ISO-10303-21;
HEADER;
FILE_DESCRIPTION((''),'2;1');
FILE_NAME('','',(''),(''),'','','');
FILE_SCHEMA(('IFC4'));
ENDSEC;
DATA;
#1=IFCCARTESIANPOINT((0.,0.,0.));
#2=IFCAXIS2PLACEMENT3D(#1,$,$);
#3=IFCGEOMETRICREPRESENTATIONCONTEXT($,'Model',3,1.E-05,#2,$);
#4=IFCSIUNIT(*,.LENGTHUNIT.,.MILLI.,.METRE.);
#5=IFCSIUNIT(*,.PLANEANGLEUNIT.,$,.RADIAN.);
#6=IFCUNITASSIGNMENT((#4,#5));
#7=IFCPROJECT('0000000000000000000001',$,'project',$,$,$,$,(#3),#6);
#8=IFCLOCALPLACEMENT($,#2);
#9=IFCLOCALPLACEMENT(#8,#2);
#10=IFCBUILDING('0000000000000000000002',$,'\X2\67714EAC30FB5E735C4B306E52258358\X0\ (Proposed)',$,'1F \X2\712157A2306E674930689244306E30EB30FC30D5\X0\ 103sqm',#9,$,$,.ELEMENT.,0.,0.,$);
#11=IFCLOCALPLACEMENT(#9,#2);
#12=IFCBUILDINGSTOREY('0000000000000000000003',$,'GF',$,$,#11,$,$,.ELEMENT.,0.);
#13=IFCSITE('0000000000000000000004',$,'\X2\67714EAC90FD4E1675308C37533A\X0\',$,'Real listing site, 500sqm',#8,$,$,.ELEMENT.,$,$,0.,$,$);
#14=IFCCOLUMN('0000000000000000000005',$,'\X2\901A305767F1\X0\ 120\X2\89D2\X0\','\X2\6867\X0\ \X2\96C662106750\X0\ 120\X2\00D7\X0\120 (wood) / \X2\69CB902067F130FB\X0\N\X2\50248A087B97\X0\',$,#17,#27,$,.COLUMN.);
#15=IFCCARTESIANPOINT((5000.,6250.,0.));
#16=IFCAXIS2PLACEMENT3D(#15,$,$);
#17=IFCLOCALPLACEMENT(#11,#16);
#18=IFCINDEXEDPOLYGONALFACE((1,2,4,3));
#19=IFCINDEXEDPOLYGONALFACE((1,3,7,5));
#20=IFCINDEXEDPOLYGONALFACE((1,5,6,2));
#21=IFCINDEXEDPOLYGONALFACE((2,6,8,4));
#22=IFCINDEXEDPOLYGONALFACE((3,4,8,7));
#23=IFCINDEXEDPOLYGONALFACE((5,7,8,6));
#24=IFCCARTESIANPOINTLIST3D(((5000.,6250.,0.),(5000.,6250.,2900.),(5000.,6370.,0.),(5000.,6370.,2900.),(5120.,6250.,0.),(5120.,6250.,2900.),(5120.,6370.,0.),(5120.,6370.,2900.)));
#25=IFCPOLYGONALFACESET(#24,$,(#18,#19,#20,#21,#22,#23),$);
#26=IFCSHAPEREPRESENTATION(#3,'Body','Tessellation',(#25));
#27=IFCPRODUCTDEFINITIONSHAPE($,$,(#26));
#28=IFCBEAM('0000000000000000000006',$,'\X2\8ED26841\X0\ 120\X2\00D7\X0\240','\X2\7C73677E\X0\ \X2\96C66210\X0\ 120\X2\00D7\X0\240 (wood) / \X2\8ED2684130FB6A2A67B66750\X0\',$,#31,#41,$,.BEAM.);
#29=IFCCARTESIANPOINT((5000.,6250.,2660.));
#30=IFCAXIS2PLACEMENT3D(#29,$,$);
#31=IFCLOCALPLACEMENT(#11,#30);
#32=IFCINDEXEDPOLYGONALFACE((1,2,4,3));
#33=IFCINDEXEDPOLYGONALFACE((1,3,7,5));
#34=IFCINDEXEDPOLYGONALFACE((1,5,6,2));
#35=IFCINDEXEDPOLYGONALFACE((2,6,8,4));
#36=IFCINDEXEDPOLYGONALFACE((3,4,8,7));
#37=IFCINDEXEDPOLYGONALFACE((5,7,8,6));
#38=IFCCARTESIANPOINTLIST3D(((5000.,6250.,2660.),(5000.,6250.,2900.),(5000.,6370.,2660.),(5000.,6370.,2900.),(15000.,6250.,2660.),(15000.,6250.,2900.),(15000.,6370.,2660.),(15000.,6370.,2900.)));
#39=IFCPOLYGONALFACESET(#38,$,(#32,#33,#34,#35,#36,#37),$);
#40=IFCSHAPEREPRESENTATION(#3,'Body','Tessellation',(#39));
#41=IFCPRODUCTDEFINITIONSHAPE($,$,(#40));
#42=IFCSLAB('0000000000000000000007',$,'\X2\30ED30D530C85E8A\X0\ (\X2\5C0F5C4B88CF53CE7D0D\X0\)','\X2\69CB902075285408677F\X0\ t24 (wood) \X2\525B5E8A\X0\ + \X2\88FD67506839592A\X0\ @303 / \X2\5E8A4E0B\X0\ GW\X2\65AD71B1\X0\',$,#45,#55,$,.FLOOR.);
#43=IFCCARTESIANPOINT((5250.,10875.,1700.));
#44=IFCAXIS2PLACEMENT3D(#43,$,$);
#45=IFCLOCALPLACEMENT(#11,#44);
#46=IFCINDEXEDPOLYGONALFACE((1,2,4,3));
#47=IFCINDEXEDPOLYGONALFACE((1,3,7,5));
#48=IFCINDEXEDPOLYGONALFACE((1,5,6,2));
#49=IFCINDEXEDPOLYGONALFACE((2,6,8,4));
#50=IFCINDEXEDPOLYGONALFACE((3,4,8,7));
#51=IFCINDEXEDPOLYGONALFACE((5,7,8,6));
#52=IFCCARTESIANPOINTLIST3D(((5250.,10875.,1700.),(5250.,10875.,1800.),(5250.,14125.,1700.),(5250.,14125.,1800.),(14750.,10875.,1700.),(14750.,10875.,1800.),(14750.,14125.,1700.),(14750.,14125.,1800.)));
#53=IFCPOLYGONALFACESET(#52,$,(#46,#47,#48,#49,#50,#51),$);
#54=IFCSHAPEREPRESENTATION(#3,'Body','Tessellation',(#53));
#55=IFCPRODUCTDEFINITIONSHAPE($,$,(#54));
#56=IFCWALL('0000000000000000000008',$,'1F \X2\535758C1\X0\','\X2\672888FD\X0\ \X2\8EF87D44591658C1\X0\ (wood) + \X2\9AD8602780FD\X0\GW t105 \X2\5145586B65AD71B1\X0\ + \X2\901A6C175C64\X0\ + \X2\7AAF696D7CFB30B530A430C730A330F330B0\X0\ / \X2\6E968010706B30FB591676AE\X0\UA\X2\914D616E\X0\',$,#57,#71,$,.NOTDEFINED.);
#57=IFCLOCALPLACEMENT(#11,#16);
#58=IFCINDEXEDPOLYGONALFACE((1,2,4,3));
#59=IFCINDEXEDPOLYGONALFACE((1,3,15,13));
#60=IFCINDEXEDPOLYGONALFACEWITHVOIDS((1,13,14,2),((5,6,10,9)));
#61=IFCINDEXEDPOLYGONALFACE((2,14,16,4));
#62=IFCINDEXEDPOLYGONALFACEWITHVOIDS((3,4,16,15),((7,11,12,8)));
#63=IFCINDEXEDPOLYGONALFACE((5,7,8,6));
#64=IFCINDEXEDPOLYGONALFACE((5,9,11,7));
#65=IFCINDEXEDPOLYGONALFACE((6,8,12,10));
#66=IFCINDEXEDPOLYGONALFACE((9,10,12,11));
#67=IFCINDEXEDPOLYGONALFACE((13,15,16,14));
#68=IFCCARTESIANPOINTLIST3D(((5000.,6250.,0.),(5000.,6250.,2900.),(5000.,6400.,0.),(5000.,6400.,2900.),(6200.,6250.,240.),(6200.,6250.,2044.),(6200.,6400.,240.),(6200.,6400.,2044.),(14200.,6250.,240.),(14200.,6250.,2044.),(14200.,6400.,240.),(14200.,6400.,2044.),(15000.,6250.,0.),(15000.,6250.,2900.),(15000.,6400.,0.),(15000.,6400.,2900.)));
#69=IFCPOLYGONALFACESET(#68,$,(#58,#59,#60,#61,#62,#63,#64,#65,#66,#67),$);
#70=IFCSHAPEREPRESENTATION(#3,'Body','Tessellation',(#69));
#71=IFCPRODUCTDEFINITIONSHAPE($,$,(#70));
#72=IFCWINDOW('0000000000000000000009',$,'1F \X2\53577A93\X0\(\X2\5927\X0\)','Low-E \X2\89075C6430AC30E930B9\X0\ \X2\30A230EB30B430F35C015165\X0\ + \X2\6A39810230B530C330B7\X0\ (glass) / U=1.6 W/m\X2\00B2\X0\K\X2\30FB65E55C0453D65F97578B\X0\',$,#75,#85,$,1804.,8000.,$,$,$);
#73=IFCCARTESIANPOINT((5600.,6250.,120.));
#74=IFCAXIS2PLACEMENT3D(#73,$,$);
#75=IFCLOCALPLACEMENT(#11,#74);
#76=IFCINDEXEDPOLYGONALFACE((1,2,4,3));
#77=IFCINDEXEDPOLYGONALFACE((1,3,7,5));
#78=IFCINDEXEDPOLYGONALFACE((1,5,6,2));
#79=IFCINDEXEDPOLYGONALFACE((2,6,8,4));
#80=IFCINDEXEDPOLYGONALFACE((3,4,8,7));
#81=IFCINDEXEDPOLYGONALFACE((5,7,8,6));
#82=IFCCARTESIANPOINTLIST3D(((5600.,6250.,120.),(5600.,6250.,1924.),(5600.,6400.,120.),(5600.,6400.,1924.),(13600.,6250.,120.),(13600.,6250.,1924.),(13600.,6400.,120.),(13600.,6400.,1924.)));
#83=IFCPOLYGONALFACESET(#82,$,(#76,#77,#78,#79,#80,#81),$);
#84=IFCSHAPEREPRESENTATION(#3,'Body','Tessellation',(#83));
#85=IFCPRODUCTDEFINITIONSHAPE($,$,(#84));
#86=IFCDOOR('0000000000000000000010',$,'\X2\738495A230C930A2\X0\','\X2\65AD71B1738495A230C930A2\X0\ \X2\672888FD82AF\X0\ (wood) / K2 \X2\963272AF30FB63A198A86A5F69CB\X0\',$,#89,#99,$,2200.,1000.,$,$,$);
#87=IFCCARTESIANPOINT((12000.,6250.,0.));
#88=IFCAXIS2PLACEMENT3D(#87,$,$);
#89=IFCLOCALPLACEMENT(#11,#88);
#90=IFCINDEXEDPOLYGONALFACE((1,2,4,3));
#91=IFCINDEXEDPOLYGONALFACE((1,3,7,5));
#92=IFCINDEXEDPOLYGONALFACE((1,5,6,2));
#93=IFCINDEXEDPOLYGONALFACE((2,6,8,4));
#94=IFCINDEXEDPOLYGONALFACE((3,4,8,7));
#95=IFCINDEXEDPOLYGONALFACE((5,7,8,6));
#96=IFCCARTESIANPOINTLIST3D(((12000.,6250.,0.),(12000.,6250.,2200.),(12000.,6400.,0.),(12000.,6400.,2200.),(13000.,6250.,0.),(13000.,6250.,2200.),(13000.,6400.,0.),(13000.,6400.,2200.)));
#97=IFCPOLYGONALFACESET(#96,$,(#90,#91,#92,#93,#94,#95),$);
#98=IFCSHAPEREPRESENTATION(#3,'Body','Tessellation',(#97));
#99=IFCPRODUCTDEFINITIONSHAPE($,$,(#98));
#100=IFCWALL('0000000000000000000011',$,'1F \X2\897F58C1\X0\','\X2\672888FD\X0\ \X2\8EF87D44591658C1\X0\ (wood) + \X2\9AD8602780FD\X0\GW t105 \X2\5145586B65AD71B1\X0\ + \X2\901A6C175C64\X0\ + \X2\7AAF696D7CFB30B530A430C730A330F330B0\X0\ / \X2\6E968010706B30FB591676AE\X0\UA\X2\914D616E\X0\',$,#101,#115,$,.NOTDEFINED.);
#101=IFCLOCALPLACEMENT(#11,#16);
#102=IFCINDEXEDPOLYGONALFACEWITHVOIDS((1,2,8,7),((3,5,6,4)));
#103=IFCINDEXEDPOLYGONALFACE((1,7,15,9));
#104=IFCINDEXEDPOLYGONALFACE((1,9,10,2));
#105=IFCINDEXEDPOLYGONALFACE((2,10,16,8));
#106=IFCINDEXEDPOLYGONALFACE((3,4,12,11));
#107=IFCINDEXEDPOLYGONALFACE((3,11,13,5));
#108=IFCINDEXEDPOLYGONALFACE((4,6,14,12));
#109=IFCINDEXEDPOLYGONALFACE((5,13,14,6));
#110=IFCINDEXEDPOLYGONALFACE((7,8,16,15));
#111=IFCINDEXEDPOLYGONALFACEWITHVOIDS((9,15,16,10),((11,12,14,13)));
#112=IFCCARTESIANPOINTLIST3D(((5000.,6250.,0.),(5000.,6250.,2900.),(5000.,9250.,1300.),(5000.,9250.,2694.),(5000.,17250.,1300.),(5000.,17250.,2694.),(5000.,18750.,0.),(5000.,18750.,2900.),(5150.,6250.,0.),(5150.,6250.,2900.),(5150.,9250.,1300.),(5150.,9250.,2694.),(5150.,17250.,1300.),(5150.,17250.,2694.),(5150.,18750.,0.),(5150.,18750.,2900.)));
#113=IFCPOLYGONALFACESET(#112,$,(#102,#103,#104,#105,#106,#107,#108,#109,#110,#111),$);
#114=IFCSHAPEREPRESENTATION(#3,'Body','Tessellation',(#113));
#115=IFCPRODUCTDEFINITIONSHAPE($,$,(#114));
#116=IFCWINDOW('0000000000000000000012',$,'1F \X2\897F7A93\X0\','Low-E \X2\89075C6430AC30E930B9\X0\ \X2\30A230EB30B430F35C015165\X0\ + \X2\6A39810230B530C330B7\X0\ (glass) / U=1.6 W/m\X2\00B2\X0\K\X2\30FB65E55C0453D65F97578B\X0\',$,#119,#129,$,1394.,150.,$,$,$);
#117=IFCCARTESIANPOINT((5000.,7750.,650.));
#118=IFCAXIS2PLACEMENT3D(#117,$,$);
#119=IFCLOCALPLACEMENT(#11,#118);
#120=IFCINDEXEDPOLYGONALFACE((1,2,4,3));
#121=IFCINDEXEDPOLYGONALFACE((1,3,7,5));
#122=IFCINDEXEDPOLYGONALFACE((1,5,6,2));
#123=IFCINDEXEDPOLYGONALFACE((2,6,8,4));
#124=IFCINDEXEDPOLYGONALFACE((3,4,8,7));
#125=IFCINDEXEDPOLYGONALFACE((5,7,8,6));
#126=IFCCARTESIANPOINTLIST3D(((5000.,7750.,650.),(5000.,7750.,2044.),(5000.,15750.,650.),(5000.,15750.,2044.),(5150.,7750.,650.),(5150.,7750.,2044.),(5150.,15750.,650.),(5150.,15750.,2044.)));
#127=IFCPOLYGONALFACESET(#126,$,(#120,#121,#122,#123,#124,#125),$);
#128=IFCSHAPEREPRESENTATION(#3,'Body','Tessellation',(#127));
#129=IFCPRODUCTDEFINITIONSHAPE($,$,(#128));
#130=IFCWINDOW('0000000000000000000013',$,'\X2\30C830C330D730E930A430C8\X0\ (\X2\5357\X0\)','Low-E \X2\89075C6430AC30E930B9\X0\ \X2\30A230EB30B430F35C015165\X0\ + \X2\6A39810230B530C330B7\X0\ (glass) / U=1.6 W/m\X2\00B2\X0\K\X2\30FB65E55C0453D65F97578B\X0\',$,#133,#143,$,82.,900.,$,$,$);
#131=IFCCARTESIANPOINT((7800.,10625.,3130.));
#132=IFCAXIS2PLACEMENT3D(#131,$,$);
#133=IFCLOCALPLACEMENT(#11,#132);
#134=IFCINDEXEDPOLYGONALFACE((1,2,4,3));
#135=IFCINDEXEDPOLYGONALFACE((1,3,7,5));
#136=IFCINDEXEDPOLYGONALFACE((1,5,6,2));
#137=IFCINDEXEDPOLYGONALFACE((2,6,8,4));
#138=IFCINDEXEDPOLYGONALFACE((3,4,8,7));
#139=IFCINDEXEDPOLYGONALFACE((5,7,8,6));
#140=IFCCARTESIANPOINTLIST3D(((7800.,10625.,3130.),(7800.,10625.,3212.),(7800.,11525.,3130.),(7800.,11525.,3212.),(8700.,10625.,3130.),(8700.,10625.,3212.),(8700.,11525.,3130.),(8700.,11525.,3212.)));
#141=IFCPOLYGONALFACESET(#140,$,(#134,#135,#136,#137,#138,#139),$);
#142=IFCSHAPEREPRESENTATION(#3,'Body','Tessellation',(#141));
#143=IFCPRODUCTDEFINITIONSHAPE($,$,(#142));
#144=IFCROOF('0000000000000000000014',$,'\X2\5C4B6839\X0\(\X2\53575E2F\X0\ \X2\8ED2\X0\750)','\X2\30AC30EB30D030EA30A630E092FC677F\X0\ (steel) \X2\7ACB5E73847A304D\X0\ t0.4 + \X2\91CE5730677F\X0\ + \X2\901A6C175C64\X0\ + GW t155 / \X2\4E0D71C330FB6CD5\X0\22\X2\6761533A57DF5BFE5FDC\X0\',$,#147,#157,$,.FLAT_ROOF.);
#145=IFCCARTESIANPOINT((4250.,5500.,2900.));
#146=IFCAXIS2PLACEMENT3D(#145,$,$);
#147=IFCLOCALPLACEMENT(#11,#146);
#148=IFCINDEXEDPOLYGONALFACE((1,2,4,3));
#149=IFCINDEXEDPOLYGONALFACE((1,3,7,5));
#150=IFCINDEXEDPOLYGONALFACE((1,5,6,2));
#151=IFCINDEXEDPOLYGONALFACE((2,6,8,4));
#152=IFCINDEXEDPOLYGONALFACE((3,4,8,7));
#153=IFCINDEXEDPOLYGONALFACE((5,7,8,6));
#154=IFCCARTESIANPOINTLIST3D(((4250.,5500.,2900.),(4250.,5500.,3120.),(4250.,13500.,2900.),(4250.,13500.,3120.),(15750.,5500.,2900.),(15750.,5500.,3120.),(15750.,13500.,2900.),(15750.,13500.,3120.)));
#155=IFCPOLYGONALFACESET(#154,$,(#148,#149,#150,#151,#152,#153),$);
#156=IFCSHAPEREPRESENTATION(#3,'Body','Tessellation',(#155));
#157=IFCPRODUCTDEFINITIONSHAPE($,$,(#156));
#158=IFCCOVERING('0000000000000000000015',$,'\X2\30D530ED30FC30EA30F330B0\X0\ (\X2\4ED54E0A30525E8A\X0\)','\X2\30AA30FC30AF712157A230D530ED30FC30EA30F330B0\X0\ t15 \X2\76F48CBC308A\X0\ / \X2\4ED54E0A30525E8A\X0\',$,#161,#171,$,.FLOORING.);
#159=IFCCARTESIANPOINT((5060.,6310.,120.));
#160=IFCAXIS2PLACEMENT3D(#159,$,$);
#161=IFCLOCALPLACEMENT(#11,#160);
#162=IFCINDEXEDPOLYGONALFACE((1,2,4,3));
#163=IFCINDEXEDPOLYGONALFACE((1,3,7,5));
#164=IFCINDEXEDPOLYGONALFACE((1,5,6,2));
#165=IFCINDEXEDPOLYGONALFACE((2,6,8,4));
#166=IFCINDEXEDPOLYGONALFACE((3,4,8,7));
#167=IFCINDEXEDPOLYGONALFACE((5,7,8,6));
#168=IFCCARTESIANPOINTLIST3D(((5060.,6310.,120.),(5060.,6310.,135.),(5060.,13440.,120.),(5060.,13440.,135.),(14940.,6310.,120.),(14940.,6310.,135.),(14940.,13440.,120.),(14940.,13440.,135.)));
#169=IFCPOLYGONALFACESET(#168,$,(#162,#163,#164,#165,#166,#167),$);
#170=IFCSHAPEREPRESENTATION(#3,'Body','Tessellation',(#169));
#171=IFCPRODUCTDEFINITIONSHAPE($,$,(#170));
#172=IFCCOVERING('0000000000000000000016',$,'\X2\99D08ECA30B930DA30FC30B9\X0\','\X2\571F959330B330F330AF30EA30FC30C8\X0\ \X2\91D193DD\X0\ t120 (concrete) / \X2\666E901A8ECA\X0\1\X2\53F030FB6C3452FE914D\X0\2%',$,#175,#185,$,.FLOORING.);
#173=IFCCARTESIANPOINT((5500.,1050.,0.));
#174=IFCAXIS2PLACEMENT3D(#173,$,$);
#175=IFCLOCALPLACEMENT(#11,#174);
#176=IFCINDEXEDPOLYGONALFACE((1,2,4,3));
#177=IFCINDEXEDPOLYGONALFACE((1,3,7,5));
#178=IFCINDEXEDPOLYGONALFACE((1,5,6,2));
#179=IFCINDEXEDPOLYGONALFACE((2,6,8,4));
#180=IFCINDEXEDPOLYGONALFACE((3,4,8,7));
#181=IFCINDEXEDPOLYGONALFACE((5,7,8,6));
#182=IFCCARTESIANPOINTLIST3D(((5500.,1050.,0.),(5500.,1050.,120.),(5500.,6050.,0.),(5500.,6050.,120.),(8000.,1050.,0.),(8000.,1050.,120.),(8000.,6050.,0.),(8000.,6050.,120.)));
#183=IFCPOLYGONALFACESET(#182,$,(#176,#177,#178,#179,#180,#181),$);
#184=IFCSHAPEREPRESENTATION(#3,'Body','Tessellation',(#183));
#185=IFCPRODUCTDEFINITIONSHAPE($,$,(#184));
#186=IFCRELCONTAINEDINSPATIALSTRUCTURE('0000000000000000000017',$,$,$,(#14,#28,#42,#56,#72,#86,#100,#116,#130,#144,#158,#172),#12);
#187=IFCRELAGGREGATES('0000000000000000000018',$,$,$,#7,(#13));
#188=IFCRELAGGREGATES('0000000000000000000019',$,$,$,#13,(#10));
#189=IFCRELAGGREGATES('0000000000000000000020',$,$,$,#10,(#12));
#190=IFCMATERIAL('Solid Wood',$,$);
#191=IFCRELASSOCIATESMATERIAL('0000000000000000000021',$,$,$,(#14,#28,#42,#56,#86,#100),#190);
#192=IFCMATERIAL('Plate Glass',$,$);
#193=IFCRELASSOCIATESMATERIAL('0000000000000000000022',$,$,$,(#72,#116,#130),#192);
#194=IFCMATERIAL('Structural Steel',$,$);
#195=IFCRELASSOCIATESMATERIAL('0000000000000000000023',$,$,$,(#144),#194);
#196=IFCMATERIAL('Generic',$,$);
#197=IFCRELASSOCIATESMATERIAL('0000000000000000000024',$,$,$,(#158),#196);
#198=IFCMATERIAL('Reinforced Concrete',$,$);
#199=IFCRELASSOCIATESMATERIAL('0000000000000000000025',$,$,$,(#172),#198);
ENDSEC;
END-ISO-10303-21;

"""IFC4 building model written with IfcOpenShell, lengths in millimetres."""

from ifc_helpers import new_model, si_unit, frame, frame_2d, origin, place, context, project, spatial, rectangle, extrude, material, element, fill, save


model = new_model("IFC4")

# Units and contexts
model_context = context("Model", 3, precision=1e-05, world=origin())
ifc_project = project(units=[si_unit("LENGTHUNIT", "METRE", prefix="MILLI"), si_unit("PLANEANGLEUNIT", "RADIAN")], contexts=[model_context])

# Site, building, storey
site_placement = place(None, origin())
site = spatial("IfcSite", under=ifc_project, at=site_placement, Name="東京都世田谷区", ObjectType="Real listing site, 500sqm", CompositionType="ELEMENT", RefElevation=0.0)
building_placement = place(site_placement, origin())
building = spatial("IfcBuilding", under=site, at=building_placement, Name="東京・平屋の別荘 (Proposed)", ObjectType="1F 無垢の杉と鉄のルーフ 103sqm", CompositionType="ELEMENT", ElevationOfRefHeight=0.0, ElevationOfTerrain=0.0)
storey_placement = place(building_placement, origin())
storey = spatial("IfcBuildingStorey", under=building, at=storey_placement, Name="GF", CompositionType="ELEMENT", Elevation=0.0)

# Column
ifc_material_1 = material(Name="Solid Wood")
column_1_placement = place(storey_placement, frame((5000.0, 6250.0, 0.0)))
element("IfcColumn", 1, at=column_1_placement, inside=storey, material=ifc_material_1, Name="通し柱 120角", Description="桧 集成材 120×120 (wood) / 構造柱・N値計算", PredefinedType="COLUMN", context=model_context, shape_type="SweptSolid", body=[
    extrude(rectangle(XDim=120.0, YDim=120.0, at=frame_2d((60.0, 60.0))), frame((5000.0, 6250.0, 0.0)), (0.0, 0.0, 1.0), 2900.0),
])

# Beam
beam_1_placement = place(storey_placement, frame((5000.0, 6250.0, 2660.0)))
element("IfcBeam", 2, at=beam_1_placement, inside=storey, material=ifc_material_1, Name="軒桁 120×240", Description="米松 集成 120×240 (wood) / 軒桁・横架材", PredefinedType="BEAM", context=model_context, shape_type="SweptSolid", body=[
    extrude(rectangle(XDim=10000.0, YDim=120.0, at=frame_2d((5000.0, 60.0))), frame((5000.0, 6250.0, 2660.0)), (0.0, 0.0, 1.0), 240.0),
])

# Slab
ifc_material_2 = material(Name="Reinforced Concrete")
slab_1_placement = place(storey_placement, frame((5250.0, 10875.0, 1700.0)))
element("IfcSlab", 3, at=slab_1_placement, inside=storey, material=ifc_material_1, Name="ロフト床 (小屋裏収納)", Description="構造用合板 t24 (wood) 剛床 + 製材根太 @303 / 床下 GW断熱", PredefinedType="FLOOR", context=model_context, shape_type="SweptSolid", body=[
    extrude(rectangle(XDim=9500.0, YDim=3250.0, at=frame_2d((4750.0, 1625.0))), frame((5250.0, 10875.0, 1700.0)), (0.0, 0.0, 1.0), 100.0),
])

# Wall, openings, window, door
wall_1_placement = place(storey_placement, frame((5000.0, 6250.0, 0.0)))
wall_1 = element("IfcWall", 4, at=wall_1_placement, inside=storey, material=ifc_material_1, Name="1F 南壁", Description="木製 軸組外壁 (wood) + 高性能GW t105 充填断熱 + 通気層 + 窯業系サイディング / 準耐火・外皮UA配慮", PredefinedType="NOTDEFINED", context=model_context, shape_type="SweptSolid", body=[
    extrude(rectangle(XDim=10000.0, YDim=150.0, at=frame_2d((5000.0, 75.0))), frame((5000.0, 6250.0, 0.0)), (0.0, 0.0, 1.0), 2900.0),
])
opening_1_placement = place(storey_placement, frame((5600.0, 6250.0, 120.0)))
opening_1 = element("IfcOpeningElement", 5, at=opening_1_placement, cuts=wall_1, PredefinedType="NOTDEFINED", context=model_context, shape_type="SweptSolid", body=[
    extrude(rectangle(XDim=8000.0, YDim=150.0, at=frame_2d((4000.0, 75.0))), frame((5600.0, 6250.0, 120.0)), (0.0, 0.0, 1.0), 1804.0),
])
opening_2_placement = place(storey_placement, frame((12000.0, 6250.0, 0.0)))
opening_2 = element("IfcOpeningElement", 6, at=opening_2_placement, cuts=wall_1, PredefinedType="NOTDEFINED", context=model_context, shape_type="SweptSolid", body=[
    extrude(rectangle(XDim=1000.0, YDim=150.0, at=frame_2d((500.0, 75.0))), frame((12000.0, 6250.0, 0.0)), (0.0, 0.0, 1.0), 2200.0),
])
ifc_material_3 = material(Name="Plate Glass")
window_1_placement = place(storey_placement, frame((5600.0, 6250.0, 120.0)))
window_1 = element("IfcWindow", 7, at=window_1_placement, inside=storey, material=ifc_material_3, Name="1F 南窓(大)", Description="Low-E 複層ガラス アルゴン封入 + 樹脂サッシ (glass) / U=1.6 W/m²K・日射取得型", OverallHeight=1804.0, OverallWidth=8000.0, context=model_context, shape_type="SweptSolid", body=[
    extrude(rectangle(XDim=8000.0, YDim=150.0, at=frame_2d((4000.0, 75.0))), frame((5600.0, 6250.0, 120.0)), (0.0, 0.0, 1.0), 1804.0),
])
fill(opening_1, window_1)
door_1_placement = place(storey_placement, frame((12000.0, 6250.0, 0.0)))
door_1 = element("IfcDoor", 8, at=door_1_placement, inside=storey, material=ifc_material_1, Name="玄関ドア", Description="断熱玄関ドア 木製芯 (wood) / K2 防犯・採風機構", OverallHeight=2200.0, OverallWidth=1000.0, context=model_context, shape_type="SweptSolid", body=[
    extrude(rectangle(XDim=1000.0, YDim=150.0, at=frame_2d((500.0, 75.0))), frame((12000.0, 6250.0, 0.0)), (0.0, 0.0, 1.0), 2200.0),
])
fill(opening_2, door_1)

# Wall, opening, window
wall_2_placement = place(storey_placement, frame((5000.0, 6250.0, 0.0)))
wall_2 = element("IfcWall", 9, at=wall_2_placement, inside=storey, material=ifc_material_1, Name="1F 西壁", Description="木製 軸組外壁 (wood) + 高性能GW t105 充填断熱 + 通気層 + 窯業系サイディング / 準耐火・外皮UA配慮", PredefinedType="NOTDEFINED", context=model_context, shape_type="SweptSolid", body=[
    extrude(rectangle(XDim=150.0, YDim=12500.0, at=frame_2d((75.0, 6250.0))), frame((5000.0, 6250.0, 0.0)), (0.0, 0.0, 1.0), 2900.0),
])
opening_3_placement = place(storey_placement, frame((5000.0, 7750.0, 650.0)))
opening_3 = element("IfcOpeningElement", 10, at=opening_3_placement, cuts=wall_2, PredefinedType="NOTDEFINED", context=model_context, shape_type="SweptSolid", body=[
    extrude(rectangle(XDim=150.0, YDim=8000.0, at=frame_2d((75.0, 4000.0))), frame((5000.0, 7750.0, 650.0)), (0.0, 0.0, 1.0), 1394.0),
])
window_2_placement = place(storey_placement, frame((5000.0, 7750.0, 650.0)))
window_2 = element("IfcWindow", 11, at=window_2_placement, inside=storey, material=ifc_material_3, Name="1F 西窓", Description="Low-E 複層ガラス アルゴン封入 + 樹脂サッシ (glass) / U=1.6 W/m²K・日射取得型", OverallHeight=1394.0, OverallWidth=150.0, context=model_context, shape_type="SweptSolid", body=[
    extrude(rectangle(XDim=150.0, YDim=8000.0, at=frame_2d((75.0, 4000.0))), frame((5000.0, 7750.0, 650.0)), (0.0, 0.0, 1.0), 1394.0),
])
fill(opening_3, window_2)

# Window
window_3_placement = place(storey_placement, frame((7800.0, 10625.0, 3130.0)))
element("IfcWindow", 12, at=window_3_placement, inside=storey, material=ifc_material_3, Name="トップライト (南)", Description="Low-E 複層ガラス アルゴン封入 + 樹脂サッシ (glass) / U=1.6 W/m²K・日射取得型", OverallHeight=82.0, OverallWidth=900.0, context=model_context, shape_type="SweptSolid", body=[
    extrude(rectangle(XDim=900.0, YDim=900.0, at=frame_2d((450.0, 450.0))), frame((7800.0, 10625.0, 3130.0)), (0.0, 0.0, 1.0), 82.0),
])

# Roof
ifc_material_4 = material(Name="Structural Steel")
roof_placement = place(storey_placement, frame((4250.0, 5500.0, 2900.0)))
element("IfcRoof", 13, at=roof_placement, inside=storey, material=ifc_material_4, Name="屋根(南帯 軒750)", Description="ガルバリウム鋼板 (steel) 立平葺き t0.4 + 野地板 + 通気層 + GW t155 / 不燃・法22条区域対応", PredefinedType="FLAT_ROOF", context=model_context, shape_type="SweptSolid", body=[
    extrude(rectangle(XDim=11500.0, YDim=8000.0, at=frame_2d((5750.0, 4000.0))), frame((4250.0, 5500.0, 2900.0)), (0.0, 0.0, 1.0), 220.0),
])

# Coverings
ifc_material_5 = material(Name="Generic")
covering_1_placement = place(storey_placement, frame((5060.0, 6310.0, 120.0)))
element("IfcCovering", 14, at=covering_1_placement, inside=storey, material=ifc_material_5, Name="フローリング (仕上げ床)", Description="オーク無垢フローリング t15 直貼り / 仕上げ床", PredefinedType="FLOORING", context=model_context, shape_type="SweptSolid", body=[
    extrude(rectangle(XDim=9880.0, YDim=7130.0, at=frame_2d((4940.0, 3565.0))), frame((5060.0, 6310.0, 120.0)), (0.0, 0.0, 1.0), 15.0),
])
covering_2_placement = place(storey_placement, frame((5500.0, 1050.0, 0.0)))
element("IfcCovering", 15, at=covering_2_placement, inside=storey, material=ifc_material_2, Name="駐車スペース", Description="土間コンクリート 金鏝 t120 (concrete) / 普通車1台・水勾配2%", PredefinedType="FLOORING", context=model_context, shape_type="SweptSolid", body=[
    extrude(rectangle(XDim=2500.0, YDim=5000.0, at=frame_2d((1250.0, 2500.0))), frame((5500.0, 1050.0, 0.0)), (0.0, 0.0, 1.0), 120.0),
])

save(model, "model.ifc")
